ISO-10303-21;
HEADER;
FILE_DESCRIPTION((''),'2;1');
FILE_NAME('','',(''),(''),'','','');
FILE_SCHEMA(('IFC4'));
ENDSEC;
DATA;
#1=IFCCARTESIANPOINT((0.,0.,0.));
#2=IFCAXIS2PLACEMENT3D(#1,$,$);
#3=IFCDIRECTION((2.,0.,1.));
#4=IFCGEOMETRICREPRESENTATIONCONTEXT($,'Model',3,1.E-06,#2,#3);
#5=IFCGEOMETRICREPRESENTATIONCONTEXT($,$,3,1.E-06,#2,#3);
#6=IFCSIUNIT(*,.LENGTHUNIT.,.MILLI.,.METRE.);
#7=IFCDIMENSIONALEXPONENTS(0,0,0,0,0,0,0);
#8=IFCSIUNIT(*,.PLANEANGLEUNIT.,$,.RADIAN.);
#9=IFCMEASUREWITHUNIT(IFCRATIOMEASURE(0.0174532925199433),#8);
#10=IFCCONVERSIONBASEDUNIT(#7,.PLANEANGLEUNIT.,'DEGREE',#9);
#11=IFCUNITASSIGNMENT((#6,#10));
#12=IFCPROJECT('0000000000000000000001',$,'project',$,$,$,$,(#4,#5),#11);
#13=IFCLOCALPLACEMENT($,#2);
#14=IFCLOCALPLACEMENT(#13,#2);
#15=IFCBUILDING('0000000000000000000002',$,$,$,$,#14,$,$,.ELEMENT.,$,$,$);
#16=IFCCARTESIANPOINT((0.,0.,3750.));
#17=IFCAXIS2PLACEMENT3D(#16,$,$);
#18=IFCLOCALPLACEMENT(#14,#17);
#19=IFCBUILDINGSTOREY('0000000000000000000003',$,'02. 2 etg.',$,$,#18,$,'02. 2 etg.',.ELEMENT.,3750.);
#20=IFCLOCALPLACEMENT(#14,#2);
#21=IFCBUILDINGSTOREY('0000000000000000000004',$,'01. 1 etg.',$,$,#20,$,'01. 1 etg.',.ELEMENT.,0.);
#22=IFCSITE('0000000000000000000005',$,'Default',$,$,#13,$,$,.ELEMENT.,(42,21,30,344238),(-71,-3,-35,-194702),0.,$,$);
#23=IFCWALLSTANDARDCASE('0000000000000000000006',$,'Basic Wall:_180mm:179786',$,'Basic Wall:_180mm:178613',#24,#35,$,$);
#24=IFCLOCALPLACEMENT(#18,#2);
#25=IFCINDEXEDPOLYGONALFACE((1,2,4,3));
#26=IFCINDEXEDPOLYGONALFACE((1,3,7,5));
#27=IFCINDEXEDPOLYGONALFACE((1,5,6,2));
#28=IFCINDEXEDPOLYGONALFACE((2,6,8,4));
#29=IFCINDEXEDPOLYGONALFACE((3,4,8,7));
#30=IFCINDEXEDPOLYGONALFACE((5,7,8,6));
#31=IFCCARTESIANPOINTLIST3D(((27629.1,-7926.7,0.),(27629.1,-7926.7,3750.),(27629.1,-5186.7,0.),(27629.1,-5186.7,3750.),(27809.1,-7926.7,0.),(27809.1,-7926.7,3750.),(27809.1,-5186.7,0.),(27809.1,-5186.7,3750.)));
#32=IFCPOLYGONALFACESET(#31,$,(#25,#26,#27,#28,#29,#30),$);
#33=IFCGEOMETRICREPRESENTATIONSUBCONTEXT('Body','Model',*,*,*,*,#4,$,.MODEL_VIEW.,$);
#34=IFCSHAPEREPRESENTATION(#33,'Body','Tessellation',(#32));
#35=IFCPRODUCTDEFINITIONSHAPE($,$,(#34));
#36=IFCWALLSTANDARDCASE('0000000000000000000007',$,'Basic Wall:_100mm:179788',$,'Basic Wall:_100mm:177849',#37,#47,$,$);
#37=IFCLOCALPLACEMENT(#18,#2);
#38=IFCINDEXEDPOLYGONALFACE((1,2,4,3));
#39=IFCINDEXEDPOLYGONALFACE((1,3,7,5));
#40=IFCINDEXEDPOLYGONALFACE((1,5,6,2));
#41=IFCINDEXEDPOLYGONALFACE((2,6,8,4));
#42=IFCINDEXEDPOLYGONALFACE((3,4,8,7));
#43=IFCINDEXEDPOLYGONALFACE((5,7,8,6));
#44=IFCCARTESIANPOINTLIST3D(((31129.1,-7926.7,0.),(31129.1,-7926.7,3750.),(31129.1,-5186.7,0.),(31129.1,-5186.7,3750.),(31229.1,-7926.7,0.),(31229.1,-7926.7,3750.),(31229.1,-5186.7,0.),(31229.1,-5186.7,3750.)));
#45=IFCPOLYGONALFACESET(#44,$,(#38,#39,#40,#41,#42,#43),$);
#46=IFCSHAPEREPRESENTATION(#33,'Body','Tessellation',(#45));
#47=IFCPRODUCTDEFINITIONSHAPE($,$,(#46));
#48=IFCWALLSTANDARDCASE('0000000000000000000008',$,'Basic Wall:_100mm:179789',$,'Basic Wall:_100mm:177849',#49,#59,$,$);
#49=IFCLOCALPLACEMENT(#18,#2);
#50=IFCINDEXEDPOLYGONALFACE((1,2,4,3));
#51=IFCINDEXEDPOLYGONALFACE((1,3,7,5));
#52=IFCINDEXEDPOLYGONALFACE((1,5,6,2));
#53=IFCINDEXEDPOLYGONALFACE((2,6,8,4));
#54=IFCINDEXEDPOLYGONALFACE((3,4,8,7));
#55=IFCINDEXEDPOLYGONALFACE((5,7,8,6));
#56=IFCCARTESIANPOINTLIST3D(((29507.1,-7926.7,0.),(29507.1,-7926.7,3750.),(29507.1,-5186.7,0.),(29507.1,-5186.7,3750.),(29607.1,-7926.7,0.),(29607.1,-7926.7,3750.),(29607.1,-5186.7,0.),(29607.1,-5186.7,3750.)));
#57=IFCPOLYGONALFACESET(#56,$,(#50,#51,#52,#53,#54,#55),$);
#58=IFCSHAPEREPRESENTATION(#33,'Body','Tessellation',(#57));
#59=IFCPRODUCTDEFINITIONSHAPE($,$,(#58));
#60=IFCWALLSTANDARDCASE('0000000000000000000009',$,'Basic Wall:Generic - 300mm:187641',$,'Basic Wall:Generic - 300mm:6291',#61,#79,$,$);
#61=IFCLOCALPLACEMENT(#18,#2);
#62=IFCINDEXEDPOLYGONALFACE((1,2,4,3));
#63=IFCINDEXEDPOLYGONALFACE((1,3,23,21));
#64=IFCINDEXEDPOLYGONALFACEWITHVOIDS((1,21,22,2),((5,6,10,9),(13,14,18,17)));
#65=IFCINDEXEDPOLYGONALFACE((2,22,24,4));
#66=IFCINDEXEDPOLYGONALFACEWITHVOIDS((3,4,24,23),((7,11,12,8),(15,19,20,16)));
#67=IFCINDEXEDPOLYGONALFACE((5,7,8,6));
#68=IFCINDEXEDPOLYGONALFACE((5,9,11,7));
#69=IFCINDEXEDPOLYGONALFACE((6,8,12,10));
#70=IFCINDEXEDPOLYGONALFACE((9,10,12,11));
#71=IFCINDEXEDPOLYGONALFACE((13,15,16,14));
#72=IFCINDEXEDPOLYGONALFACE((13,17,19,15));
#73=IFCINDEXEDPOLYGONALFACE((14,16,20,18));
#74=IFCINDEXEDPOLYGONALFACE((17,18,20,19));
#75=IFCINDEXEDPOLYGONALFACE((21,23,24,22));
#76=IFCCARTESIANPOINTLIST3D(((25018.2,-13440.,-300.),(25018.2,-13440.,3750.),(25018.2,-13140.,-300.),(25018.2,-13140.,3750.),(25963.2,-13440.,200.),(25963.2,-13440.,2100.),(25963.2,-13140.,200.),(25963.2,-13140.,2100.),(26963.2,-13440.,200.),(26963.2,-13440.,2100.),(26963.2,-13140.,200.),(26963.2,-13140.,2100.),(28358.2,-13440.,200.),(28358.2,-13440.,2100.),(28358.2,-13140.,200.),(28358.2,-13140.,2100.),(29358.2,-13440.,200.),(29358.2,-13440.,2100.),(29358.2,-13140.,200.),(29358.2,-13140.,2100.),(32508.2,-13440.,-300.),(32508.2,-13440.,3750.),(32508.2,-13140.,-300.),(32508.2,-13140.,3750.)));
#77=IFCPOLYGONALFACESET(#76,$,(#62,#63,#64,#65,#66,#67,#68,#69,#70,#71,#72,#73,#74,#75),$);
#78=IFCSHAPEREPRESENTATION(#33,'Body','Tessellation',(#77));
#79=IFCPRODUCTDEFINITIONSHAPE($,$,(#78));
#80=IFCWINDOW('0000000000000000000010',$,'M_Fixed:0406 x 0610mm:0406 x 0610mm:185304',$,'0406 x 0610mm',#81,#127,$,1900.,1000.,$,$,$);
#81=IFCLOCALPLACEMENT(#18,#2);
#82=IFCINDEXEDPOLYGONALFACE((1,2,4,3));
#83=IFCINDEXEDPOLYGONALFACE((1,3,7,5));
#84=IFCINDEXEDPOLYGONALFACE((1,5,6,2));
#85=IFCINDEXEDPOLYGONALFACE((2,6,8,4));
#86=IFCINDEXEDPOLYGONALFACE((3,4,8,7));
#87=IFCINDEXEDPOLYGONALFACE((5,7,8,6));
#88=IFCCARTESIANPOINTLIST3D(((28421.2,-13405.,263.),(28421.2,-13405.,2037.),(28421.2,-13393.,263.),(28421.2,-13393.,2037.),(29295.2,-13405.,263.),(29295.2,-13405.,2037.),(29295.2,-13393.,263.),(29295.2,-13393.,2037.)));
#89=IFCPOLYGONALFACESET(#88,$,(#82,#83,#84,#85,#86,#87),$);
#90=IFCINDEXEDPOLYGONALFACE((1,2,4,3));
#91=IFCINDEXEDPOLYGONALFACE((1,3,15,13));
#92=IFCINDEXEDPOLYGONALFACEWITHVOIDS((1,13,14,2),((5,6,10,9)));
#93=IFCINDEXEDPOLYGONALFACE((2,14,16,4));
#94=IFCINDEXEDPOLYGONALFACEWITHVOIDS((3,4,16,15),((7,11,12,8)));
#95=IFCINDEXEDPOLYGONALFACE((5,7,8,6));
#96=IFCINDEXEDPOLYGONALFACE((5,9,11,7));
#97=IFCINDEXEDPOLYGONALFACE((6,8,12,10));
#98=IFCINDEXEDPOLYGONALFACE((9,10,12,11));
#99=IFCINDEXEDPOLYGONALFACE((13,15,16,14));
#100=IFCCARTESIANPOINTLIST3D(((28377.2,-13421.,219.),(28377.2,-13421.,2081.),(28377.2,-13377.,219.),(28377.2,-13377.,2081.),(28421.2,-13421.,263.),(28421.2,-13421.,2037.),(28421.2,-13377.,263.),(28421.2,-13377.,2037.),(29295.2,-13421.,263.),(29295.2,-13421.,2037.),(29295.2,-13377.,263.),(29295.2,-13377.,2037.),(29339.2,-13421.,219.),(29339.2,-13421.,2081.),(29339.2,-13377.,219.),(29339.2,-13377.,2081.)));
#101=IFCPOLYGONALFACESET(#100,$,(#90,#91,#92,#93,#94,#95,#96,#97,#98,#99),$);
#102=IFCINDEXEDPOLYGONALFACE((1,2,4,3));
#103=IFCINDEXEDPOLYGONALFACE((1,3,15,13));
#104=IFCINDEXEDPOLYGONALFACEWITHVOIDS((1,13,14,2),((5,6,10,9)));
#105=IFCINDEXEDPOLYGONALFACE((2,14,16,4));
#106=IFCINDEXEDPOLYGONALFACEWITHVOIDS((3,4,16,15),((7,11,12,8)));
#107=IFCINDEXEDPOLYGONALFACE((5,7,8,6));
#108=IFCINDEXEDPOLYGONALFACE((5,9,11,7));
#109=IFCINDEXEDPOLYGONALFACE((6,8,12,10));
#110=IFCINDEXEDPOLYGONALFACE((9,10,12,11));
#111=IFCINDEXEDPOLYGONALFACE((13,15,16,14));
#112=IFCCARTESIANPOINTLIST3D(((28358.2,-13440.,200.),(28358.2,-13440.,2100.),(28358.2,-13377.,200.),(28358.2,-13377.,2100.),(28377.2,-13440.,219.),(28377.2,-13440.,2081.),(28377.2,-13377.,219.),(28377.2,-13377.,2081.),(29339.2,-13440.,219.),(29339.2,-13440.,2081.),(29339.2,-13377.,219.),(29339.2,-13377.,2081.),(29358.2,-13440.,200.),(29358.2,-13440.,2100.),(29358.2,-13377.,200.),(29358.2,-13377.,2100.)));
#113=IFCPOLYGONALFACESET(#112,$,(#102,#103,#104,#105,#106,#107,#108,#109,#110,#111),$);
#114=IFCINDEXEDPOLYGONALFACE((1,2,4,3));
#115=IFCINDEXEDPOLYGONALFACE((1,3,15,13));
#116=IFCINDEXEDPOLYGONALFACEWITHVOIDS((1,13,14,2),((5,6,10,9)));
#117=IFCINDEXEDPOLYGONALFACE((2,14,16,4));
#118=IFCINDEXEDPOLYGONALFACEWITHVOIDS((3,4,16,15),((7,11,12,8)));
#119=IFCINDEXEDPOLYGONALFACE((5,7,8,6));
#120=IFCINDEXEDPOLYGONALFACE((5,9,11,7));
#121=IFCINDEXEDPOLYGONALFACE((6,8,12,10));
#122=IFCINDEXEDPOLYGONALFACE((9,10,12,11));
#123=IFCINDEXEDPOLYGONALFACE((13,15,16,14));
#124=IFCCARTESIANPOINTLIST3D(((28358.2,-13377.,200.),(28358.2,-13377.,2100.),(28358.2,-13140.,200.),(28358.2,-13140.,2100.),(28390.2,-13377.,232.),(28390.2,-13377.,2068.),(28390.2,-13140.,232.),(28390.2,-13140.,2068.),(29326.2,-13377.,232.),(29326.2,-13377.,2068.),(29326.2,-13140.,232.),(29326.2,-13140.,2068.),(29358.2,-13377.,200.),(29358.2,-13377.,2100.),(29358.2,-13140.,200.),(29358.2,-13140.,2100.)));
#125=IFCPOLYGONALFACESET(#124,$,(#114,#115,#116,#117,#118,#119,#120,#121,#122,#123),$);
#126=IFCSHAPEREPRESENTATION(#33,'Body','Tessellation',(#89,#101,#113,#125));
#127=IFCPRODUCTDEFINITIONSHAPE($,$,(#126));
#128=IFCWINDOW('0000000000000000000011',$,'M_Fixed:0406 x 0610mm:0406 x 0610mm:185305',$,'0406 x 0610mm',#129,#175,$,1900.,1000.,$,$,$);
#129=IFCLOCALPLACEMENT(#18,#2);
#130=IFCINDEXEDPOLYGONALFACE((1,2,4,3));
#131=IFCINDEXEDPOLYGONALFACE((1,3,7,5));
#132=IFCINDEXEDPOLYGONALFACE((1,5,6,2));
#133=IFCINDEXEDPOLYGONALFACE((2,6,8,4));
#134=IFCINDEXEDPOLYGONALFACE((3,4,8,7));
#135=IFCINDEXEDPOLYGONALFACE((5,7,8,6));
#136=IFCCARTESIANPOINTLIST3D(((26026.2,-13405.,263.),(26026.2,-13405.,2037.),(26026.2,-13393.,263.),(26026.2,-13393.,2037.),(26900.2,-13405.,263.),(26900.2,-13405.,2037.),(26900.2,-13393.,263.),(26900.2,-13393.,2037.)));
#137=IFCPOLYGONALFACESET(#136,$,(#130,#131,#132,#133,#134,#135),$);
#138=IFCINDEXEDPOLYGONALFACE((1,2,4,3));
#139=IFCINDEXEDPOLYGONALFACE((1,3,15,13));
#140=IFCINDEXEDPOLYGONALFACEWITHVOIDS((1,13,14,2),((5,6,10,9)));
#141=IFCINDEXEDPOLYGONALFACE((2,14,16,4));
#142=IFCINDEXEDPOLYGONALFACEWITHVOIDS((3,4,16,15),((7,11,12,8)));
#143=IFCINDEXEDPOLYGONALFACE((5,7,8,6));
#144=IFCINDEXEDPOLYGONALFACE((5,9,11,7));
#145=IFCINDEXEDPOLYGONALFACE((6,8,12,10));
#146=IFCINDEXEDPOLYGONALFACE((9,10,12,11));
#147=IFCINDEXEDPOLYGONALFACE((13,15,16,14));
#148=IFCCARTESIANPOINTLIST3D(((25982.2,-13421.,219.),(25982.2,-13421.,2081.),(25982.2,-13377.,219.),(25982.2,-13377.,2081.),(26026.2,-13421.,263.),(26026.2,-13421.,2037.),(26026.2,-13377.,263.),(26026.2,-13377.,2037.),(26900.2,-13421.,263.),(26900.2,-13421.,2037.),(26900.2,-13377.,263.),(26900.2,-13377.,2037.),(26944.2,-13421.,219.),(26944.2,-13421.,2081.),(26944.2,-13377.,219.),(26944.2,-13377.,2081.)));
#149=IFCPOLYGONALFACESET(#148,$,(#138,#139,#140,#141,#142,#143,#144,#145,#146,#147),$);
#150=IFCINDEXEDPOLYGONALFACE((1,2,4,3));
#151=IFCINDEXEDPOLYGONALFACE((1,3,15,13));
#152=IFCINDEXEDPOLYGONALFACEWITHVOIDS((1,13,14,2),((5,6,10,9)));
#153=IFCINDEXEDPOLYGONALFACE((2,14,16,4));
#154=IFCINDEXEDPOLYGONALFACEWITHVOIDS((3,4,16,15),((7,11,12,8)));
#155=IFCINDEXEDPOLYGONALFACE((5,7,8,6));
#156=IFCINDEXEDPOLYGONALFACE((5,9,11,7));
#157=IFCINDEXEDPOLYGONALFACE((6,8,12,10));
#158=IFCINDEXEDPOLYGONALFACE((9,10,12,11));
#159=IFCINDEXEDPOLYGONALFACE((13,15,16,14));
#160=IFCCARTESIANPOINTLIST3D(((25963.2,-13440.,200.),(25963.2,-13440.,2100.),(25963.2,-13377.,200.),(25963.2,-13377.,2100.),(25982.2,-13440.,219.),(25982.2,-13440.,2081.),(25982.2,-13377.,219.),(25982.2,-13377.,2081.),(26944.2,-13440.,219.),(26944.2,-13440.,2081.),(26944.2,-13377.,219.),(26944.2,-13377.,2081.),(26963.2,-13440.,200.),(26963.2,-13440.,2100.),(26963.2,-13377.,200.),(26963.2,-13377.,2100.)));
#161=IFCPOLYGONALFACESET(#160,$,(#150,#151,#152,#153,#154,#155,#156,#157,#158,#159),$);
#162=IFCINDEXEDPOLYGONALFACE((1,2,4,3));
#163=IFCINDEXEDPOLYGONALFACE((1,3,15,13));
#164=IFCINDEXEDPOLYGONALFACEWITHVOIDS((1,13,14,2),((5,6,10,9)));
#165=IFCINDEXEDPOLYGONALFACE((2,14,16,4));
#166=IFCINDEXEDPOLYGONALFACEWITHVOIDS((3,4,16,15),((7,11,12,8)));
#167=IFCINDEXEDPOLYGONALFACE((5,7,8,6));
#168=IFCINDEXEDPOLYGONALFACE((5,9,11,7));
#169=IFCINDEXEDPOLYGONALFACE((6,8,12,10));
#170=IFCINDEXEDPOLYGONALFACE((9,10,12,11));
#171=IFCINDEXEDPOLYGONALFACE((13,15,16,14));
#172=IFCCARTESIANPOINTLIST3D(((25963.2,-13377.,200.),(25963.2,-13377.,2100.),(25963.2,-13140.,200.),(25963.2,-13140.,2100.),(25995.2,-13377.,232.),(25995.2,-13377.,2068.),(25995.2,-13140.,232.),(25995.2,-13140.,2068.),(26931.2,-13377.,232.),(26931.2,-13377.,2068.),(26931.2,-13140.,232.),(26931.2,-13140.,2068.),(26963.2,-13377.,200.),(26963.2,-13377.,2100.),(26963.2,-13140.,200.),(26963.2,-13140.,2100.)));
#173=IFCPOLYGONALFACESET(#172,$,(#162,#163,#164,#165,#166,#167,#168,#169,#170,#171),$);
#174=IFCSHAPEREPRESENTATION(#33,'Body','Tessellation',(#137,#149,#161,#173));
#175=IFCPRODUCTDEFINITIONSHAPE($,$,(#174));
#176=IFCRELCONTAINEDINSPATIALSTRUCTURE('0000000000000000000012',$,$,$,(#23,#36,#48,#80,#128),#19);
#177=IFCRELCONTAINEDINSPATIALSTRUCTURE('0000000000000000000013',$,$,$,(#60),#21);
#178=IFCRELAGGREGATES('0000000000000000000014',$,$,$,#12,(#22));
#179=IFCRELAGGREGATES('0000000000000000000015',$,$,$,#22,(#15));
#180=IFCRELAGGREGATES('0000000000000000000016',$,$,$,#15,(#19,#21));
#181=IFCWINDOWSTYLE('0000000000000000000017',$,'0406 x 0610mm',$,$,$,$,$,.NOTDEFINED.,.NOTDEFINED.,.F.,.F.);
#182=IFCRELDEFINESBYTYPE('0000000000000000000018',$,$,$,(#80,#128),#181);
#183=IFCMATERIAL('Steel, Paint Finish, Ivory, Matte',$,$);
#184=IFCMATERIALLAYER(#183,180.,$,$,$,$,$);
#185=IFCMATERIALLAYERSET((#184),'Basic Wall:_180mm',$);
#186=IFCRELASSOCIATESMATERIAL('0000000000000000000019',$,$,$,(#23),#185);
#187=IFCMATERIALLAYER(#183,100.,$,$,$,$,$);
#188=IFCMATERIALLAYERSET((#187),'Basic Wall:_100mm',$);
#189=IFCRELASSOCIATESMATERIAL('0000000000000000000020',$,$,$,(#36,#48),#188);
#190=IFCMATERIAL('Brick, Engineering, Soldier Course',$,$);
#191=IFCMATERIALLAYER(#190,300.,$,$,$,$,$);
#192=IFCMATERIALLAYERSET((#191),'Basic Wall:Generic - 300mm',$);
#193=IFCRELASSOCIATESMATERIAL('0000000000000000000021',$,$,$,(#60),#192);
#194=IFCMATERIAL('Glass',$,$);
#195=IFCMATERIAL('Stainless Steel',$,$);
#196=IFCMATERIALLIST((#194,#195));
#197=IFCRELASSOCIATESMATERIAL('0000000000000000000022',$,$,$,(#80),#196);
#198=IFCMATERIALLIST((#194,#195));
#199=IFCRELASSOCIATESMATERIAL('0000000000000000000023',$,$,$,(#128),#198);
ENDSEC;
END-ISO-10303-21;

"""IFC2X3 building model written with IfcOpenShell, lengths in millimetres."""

from ifc_helpers import new_model, entity, si_unit, converted_unit, direction, frame, frame_2d, origin, place, context, subcontext, project, spatial, polyline, rectangle, outline, extrude, source, transform, mapped, material, material_list, layer, layer_set, layer_usage, type_object, type_shapes, element, fill, save


model = new_model("IFC2X3")

# Units and contexts
model_context = context("Model", 3, precision=1e-06, world=origin(), true_north=direction((2.0, 0.0, 1.0)))
context_of_model = context(None, 3, precision=1e-06, world=origin(), true_north=direction((2.0, 0.0, 1.0)))
body_context = subcontext(model_context, "Body", "Model", "MODEL_VIEW")
ifc_project = project(units=[si_unit("LENGTHUNIT", "METRE", prefix="MILLI"), converted_unit("PLANEANGLEUNIT", "DEGREE", entity("IfcRatioMeasure", 0.0174532925199433), si_unit("PLANEANGLEUNIT", "RADIAN"), dimensions=[0, 0, 0, 0, 0, 0, 0])], contexts=[model_context, context_of_model])

# Site, building, storey
site_placement = place(None, origin())
site = spatial("IfcSite", under=ifc_project, at=site_placement, Name="Default", CompositionType="ELEMENT", RefLatitude=(42, 21, 30, 344238), RefLongitude=(-71, -3, -35, -194702), RefElevation=0.0)
building_placement = place(site_placement, origin())
building = spatial("IfcBuilding", under=site, at=building_placement, CompositionType="ELEMENT")
storey_1_placement = place(building_placement, frame((0.0, 0.0, 3750.0)))
storey_1 = spatial("IfcBuildingStorey", under=building, at=storey_1_placement, Name="02. 2 etg.", LongName="02. 2 etg.", CompositionType="ELEMENT", Elevation=3750.0)

# Shared definitions
ifc_material_1 = material(Name="Steel, Paint Finish, Ivory, Matte")
ifc_layer_1 = layer(ifc_material_1, 100.0)
ifc_layer_set_1 = layer_set([ifc_layer_1], Name="Basic Wall:_100mm")
ifc_material_2 = material(Name="Stainless Steel")
ifc_material_3 = material(Name="Glass")

# Shared definitions
ifc_layer_2 = layer(ifc_material_1, 180.0)
ifc_layer_set_2 = layer_set([ifc_layer_2], Name="Basic Wall:_180mm")

# Walls
ifc_layer_usage_1 = layer_usage(ifc_layer_set_2, "AXIS2", "POSITIVE", -90.0)
wall_1_placement = place(storey_1_placement, frame((27719.1, -5186.7, 0.0), z_axis=(0.0, 0.0, 1.0), x_axis=(0.0, -1.0, 0.0)))
element("IfcWallStandardCase", 1, at=wall_1_placement, inside=storey_1, material=ifc_layer_usage_1, Name="Basic Wall:_180mm:179786", ObjectType="Basic Wall:_180mm:178613", context=body_context, shape_type="SweptSolid", body=[
    extrude(rectangle(XDim=2740.0, YDim=180.0, at=frame_2d((1370.0, 0.0), x_axis=(-1.0, 0.0))), origin(), (0.0, 0.0, 1.0), 3750.0),
])
ifc_layer_usage_2 = layer_usage(ifc_layer_set_1, "AXIS2", "NEGATIVE", 50.0)
wall_2_placement = place(storey_1_placement, frame((31179.1, -5186.7, 0.0), z_axis=(0.0, 0.0, 1.0), x_axis=(0.0, -1.0, 0.0)))
element("IfcWallStandardCase", 2, at=wall_2_placement, inside=storey_1, material=ifc_layer_usage_2, Name="Basic Wall:_100mm:179788", ObjectType="Basic Wall:_100mm:177849", context=body_context, shape_type="SweptSolid", body=[
    extrude(rectangle(XDim=2740.0, YDim=100.0, at=frame_2d((1370.0, 0.0), x_axis=(-1.0, 0.0))), origin(), (0.0, 0.0, 1.0), 3750.0),
])
ifc_layer_usage_3 = layer_usage(ifc_layer_set_1, "AXIS2", "POSITIVE", -50.0)
wall_3_placement = place(storey_1_placement, frame((29557.1, -5186.7, 0.0), z_axis=(0.0, 0.0, 1.0), x_axis=(0.0, -1.0, 0.0)))
element("IfcWallStandardCase", 3, at=wall_3_placement, inside=storey_1, material=ifc_layer_usage_3, Name="Basic Wall:_100mm:179789", ObjectType="Basic Wall:_100mm:177849", context=body_context, shape_type="SweptSolid", body=[
    extrude(rectangle(XDim=2740.0, YDim=100.0, at=frame_2d((1370.0, 0.0), x_axis=(-1.0, 0.0))), origin(), (0.0, 0.0, 1.0), 3750.0),
])

# Shared definitions
storey_2_placement = place(building_placement, origin())
storey_2 = spatial("IfcBuildingStorey", under=building, at=storey_2_placement, Name="01. 1 etg.", LongName="01. 1 etg.", CompositionType="ELEMENT", Elevation=0.0)

# Wall, openings, windows
ifc_material_4 = material(Name="Brick, Engineering, Soldier Course")
ifc_layer_3 = layer(ifc_material_4, 300.0)
ifc_layer_set_3 = layer_set([ifc_layer_3], Name="Basic Wall:Generic - 300mm")
ifc_layer_usage_4 = layer_usage(ifc_layer_set_3, "AXIS2", "NEGATIVE", 150.0)
wall_4_placement = place(storey_2_placement, frame((32508.2, -13290.0, 3450.0), z_axis=(0.0, 0.0, 1.0), x_axis=(-1.0, 0.0, 0.0)))
wall_4 = element("IfcWallStandardCase", 4, at=wall_4_placement, inside=storey_2, material=ifc_layer_usage_4, Name="Basic Wall:Generic - 300mm:187641", ObjectType="Basic Wall:Generic - 300mm:6291", context=body_context, shape_type="SweptSolid", body=[
    extrude(rectangle(XDim=7490.0, YDim=300.0, at=frame_2d((3745.0, 0.0), x_axis=(-1.0, 0.0))), origin(), (0.0, 0.0, 1.0), 4050.0),
])
opening_1_placement = place(wall_4_placement, frame((3150.0, -150.0, 500.0)))
opening_1 = element("IfcOpeningElement", 5, at=opening_1_placement, cuts=wall_4, ObjectType="Opening", context=body_context, shape_type="SweptSolid", body=[
    extrude(rectangle(XDim=1900.0, YDim=1000.0, at=frame_2d((950.0, 500.0), x_axis=(1.0, 0.0))), frame((0.0, 0.0, 0.0), z_axis=(0.0, 1.0, 0.0), x_axis=(0.0, 0.0, 1.0)), (0.0, 0.0, 1.0), 300.0),
])
opening_2_placement = place(wall_4_placement, frame((5545.0, -150.0, 500.0)))
opening_2 = element("IfcOpeningElement", 6, at=opening_2_placement, cuts=wall_4, ObjectType="Opening", context=body_context, shape_type="SweptSolid", body=[
    extrude(rectangle(XDim=1900.0, YDim=1000.0, at=frame_2d((950.0, 500.0), x_axis=(1.0, 0.0))), frame((0.0, 0.0, 0.0), z_axis=(0.0, 1.0, 0.0), x_axis=(0.0, 0.0, 1.0)), (0.0, 0.0, 1.0), 300.0),
])
ifc_material_list_1 = material_list([ifc_material_3, ifc_material_2])
window_style = type_object("IfcWindowStyle", Name="0406 x 0610mm", ConstructionType="NOTDEFINED", OperationType="NOTDEFINED", ParameterTakesPrecedence=False, Sizeable=False)
shared_shape_1 = source(origin(), body_context, "Body", "SweptSolid", [
    extrude(rectangle(XDim=874.0, YDim=12.0, at=frame_2d((0.0, 0.0), x_axis=(1.0, 0.0))), frame((500.0, 285.0, 63.0), z_axis=(0.0, 0.0, 1.0), x_axis=(-1.0, 0.0, 0.0)), (0.0, 0.0, 1.0), 1774.0),
    extrude(outline(polyline([(-481.0, -931.0), (481.0, -931.0), (481.0, 931.0), (-481.0, 931.0), (-481.0, -931.0)]), holes=[polyline([(-437.0, -887.0), (-437.0, 887.0), (437.0, 887.0), (437.0, -887.0), (-437.0, -887.0)])]), frame((500.0, 307.0, 950.0), z_axis=(0.0, -1.0, 0.0), x_axis=(-1.0, 0.0, 0.0)), (0.0, 0.0, 1.0), 44.0),
    extrude(outline(polyline([(-500.0, -950.0), (500.0, -950.0), (500.0, 950.0), (-500.0, 950.0), (-500.0, -950.0)]), holes=[polyline([(-481.0, -931.0), (-481.0, 931.0), (481.0, 931.0), (481.0, -931.0), (-481.0, -931.0)])]), frame((500.0, 326.0, 950.0), z_axis=(0.0, -1.0, 0.0), x_axis=(-1.0, 0.0, 0.0)), (0.0, 0.0, 1.0), 63.0),
    extrude(outline(polyline([(-500.0, -950.0), (500.0, -950.0), (500.0, 950.0), (-500.0, 950.0), (-500.0, -950.0)]), holes=[polyline([(-468.0, -918.0), (-468.0, 918.0), (468.0, 918.0), (468.0, -918.0), (-468.0, -918.0)])]), frame((500.0, 263.0, 950.0), z_axis=(0.0, -1.0, 0.0), x_axis=(-1.0, 0.0, 0.0)), (0.0, 0.0, 1.0), 237.0),
])
type_shapes(window_style, [shared_shape_1])
window_1_placement = place(opening_1_placement, frame((0.0, -26.0, 0.0)))
window_1 = element("IfcWindow", 7, at=window_1_placement, inside=storey_1, type_object=window_style, material=ifc_material_list_1, Name="M_Fixed:0406 x 0610mm:0406 x 0610mm:185304", ObjectType="0406 x 0610mm", OverallHeight=1900.0, OverallWidth=1000.0, context=body_context, shape_type="MappedRepresentation", body=[
    mapped(shared_shape_1, transform((0.0, 0.0, 0.0), scale=1.0)),
])
fill(opening_1, window_1)
ifc_material_list_2 = material_list([ifc_material_3, ifc_material_2])
window_2_placement = place(opening_2_placement, frame((0.0, -26.0, 0.0)))
window_2 = element("IfcWindow", 8, at=window_2_placement, inside=storey_1, type_object=window_style, material=ifc_material_list_2, Name="M_Fixed:0406 x 0610mm:0406 x 0610mm:185305", ObjectType="0406 x 0610mm", OverallHeight=1900.0, OverallWidth=1000.0, context=body_context, shape_type="MappedRepresentation", body=[
    mapped(shared_shape_1, transform((0.0, 0.0, 0.0), scale=1.0)),
])
fill(opening_2, window_2)

save(model, "model.ifc")
